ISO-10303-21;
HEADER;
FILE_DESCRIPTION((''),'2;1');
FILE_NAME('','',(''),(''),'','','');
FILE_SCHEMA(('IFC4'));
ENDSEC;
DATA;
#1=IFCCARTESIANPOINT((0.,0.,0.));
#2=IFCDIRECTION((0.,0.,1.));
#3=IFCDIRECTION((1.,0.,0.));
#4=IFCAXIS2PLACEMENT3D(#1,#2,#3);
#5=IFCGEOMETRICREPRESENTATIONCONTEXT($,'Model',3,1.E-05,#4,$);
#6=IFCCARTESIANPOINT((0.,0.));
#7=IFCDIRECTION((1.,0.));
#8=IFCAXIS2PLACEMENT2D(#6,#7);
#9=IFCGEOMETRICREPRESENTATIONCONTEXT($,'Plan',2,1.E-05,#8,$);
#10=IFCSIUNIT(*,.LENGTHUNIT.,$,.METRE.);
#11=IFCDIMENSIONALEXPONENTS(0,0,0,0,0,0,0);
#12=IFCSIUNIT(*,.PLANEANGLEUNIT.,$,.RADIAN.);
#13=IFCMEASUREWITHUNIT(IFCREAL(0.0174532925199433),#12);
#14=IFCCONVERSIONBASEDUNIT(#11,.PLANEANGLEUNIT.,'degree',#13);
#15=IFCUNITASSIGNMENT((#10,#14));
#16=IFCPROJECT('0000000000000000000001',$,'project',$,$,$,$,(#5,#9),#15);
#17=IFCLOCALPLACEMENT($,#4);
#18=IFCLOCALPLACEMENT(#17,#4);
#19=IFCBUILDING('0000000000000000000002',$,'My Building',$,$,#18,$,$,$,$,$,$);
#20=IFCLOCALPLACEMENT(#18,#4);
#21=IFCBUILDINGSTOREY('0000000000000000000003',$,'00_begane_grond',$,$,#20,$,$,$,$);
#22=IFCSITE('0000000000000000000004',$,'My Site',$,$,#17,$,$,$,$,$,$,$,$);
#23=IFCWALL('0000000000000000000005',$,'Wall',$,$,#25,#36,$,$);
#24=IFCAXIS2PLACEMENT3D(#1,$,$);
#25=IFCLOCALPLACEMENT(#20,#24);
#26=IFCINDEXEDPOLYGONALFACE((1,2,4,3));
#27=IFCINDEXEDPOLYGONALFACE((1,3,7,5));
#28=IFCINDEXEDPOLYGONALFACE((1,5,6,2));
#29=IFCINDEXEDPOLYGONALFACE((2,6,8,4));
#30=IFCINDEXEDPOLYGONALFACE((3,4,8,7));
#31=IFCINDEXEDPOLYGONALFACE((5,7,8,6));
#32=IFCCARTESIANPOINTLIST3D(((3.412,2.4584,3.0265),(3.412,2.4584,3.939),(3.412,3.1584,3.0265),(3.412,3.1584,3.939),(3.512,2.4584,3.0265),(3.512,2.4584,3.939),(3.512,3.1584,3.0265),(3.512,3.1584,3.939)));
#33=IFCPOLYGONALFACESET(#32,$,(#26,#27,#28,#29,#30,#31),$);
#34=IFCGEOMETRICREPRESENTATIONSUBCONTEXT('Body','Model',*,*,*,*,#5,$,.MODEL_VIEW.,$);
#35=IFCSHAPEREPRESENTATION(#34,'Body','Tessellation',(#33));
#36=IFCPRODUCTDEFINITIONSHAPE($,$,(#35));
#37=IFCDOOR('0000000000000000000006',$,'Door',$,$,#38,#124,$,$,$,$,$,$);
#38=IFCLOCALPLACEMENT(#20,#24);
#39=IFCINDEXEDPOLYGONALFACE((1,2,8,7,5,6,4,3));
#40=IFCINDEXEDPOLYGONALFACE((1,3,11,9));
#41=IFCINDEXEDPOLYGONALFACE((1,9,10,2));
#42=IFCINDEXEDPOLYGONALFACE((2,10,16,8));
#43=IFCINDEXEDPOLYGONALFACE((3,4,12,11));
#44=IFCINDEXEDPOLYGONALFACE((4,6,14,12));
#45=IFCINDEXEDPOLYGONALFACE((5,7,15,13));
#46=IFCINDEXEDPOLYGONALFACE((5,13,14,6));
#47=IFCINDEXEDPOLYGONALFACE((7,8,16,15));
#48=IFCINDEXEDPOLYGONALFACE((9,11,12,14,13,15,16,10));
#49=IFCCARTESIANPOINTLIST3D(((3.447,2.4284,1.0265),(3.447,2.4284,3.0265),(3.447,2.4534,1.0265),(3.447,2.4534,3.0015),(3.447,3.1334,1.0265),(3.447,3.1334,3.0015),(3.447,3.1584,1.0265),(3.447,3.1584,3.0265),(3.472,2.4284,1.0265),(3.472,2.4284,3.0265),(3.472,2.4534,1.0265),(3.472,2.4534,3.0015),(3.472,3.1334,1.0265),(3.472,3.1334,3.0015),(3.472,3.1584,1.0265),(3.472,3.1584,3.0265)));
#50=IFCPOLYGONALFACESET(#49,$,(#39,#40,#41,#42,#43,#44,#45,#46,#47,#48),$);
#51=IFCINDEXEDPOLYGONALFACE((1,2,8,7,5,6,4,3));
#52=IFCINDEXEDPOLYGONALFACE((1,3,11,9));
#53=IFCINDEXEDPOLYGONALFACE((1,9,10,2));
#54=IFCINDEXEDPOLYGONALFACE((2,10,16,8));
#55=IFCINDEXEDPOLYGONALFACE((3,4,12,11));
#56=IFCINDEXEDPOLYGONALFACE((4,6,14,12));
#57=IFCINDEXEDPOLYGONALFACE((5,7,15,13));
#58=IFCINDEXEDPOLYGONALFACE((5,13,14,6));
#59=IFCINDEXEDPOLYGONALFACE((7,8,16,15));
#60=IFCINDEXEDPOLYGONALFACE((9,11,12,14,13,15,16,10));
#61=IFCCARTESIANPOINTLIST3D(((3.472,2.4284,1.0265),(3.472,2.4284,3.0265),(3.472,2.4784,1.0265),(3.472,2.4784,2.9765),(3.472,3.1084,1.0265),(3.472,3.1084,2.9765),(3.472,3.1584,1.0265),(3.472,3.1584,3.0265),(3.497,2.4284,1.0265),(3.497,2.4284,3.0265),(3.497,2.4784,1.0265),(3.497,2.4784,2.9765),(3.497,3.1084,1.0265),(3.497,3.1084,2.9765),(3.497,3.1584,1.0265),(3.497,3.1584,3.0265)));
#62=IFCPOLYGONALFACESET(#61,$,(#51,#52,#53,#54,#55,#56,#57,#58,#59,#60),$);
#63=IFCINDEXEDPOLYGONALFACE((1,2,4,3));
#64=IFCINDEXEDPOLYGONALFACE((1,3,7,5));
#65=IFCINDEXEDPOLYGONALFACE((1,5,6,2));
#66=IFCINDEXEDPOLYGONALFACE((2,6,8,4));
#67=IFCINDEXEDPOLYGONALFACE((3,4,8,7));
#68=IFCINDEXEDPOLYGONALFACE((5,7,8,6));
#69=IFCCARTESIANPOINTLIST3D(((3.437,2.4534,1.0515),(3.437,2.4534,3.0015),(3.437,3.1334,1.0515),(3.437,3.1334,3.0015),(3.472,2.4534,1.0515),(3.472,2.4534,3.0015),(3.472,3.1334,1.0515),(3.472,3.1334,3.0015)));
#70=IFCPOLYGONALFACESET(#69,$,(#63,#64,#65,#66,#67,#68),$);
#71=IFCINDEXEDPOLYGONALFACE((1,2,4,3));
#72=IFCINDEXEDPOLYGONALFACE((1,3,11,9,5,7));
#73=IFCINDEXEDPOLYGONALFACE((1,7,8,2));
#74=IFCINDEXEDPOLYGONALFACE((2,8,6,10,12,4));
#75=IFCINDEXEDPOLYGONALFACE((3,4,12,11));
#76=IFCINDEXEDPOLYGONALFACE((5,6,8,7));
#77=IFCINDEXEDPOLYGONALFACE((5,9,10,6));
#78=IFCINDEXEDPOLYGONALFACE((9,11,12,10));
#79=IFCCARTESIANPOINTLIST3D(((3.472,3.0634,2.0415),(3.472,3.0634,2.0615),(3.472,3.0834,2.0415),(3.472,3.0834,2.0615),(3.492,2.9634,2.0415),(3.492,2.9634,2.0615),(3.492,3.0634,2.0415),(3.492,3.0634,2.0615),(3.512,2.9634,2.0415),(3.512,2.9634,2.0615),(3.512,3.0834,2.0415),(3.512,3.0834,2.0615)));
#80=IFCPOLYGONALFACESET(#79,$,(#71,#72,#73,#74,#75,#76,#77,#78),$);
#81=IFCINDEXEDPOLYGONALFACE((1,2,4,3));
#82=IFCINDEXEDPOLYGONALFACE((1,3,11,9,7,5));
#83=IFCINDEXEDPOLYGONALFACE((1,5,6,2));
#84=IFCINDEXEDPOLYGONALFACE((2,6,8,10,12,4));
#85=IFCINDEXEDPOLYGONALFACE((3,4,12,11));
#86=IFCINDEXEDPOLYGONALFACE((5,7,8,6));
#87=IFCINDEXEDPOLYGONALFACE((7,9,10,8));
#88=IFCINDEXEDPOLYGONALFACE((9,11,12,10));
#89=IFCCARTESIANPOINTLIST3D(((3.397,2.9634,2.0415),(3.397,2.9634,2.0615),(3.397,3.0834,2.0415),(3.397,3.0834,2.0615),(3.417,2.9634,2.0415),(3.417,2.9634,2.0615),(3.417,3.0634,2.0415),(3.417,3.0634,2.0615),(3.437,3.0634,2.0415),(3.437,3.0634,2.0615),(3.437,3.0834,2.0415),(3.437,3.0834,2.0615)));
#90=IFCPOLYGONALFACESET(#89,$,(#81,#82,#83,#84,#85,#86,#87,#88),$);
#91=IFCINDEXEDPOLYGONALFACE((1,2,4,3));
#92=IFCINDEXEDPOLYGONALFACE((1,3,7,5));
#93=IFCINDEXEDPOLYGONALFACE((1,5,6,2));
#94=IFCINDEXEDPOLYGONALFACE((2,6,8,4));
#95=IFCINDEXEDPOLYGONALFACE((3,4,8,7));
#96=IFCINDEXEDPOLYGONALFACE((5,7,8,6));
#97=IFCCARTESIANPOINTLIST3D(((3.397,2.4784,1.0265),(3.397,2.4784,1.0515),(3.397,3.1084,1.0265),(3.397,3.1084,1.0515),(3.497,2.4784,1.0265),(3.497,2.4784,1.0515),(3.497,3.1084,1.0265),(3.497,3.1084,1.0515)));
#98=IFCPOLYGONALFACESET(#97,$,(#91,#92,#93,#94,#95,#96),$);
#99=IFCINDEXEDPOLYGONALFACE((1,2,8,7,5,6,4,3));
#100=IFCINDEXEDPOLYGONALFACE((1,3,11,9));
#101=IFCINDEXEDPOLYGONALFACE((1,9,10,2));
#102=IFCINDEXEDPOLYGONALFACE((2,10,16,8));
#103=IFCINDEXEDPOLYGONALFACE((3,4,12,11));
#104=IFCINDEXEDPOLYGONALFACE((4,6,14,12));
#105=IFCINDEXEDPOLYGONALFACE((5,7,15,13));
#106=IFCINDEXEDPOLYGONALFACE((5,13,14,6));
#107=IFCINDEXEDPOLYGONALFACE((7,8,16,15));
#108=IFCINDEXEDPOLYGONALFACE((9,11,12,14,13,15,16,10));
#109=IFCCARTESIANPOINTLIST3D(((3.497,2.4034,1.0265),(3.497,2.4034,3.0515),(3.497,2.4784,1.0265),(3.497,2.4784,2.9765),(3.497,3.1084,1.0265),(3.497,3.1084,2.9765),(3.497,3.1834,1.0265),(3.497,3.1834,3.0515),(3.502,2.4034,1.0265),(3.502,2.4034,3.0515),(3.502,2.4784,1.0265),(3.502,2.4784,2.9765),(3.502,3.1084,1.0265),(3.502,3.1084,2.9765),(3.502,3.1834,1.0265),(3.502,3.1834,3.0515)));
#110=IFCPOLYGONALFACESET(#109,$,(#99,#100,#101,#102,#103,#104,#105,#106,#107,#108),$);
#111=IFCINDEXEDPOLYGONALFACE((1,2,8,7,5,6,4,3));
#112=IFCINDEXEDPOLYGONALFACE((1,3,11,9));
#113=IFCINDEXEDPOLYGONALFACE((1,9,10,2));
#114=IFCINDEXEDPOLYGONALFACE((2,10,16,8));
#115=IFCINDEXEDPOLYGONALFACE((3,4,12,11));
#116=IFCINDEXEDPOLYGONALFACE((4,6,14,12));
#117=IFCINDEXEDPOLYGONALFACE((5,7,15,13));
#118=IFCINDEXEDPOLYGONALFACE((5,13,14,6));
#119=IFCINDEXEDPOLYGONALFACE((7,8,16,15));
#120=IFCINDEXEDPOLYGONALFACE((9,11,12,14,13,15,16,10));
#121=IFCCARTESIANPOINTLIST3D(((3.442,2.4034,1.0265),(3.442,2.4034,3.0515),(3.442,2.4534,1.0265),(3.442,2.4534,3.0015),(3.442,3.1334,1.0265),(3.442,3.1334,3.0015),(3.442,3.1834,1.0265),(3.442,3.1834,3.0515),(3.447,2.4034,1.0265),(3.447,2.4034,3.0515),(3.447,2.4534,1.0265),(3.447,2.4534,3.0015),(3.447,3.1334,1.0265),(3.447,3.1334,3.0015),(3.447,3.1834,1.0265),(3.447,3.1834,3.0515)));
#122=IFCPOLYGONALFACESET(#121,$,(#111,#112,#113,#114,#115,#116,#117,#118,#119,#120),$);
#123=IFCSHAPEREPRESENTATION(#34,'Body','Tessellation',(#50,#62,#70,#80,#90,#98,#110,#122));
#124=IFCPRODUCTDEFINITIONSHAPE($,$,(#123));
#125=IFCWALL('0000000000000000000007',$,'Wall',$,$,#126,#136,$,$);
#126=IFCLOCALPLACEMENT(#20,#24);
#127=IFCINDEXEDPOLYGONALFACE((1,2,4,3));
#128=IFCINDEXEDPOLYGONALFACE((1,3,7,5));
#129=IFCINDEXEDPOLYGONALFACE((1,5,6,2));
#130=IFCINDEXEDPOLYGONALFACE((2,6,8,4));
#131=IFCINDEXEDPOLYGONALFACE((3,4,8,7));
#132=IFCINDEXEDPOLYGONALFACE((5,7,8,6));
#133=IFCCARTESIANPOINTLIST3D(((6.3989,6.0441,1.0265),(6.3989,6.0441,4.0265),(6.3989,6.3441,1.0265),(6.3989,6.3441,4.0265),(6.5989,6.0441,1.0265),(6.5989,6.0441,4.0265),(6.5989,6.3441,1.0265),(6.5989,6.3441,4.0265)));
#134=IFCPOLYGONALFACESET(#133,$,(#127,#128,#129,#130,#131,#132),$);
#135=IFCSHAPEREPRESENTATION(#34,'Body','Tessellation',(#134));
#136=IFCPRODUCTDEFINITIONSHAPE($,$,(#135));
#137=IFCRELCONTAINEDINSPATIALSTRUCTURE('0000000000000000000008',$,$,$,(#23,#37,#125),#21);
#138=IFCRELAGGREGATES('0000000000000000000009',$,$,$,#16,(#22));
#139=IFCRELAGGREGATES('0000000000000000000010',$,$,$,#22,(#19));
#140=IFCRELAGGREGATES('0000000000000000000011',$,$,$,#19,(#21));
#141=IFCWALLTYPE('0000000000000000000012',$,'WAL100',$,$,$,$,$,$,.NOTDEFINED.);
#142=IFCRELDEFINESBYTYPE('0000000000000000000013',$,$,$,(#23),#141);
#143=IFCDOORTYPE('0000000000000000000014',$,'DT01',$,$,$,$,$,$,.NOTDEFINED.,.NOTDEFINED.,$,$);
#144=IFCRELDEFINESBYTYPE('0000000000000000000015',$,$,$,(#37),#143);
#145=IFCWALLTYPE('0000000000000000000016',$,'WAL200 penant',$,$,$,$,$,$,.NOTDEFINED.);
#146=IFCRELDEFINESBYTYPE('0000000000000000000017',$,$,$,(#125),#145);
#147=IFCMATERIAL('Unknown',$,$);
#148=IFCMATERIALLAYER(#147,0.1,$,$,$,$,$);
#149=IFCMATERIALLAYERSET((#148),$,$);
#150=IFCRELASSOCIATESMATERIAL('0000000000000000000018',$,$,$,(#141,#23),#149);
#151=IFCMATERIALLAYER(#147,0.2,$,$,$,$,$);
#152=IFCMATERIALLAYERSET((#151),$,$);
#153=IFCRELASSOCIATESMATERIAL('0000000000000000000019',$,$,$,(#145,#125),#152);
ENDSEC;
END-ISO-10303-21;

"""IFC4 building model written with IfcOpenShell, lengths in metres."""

from ifc_helpers import new_model, entity, si_unit, converted_unit, frame, origin_with_axes, origin_2d_with_axis, place, context, subcontext, project, spatial, line, indexed_curve, outline, extrude, clip, halfspace, shape, source, transform, mapped, material, layer, layer_set, layer_usage, type_object, type_shapes, element, fill, save


model = new_model("IFC4")

# Units and contexts
model_context = context("Model", 3, precision=1e-05, world=origin_with_axes())
plan_context = context("Plan", 2, precision=1e-05, world=origin_2d_with_axis())
body_context_1 = subcontext(model_context, "Body", "Model", "MODEL_VIEW")
body_context_2 = subcontext(plan_context, "Body", "Plan", "PLAN_VIEW")
ifc_project = project(units=[si_unit("LENGTHUNIT", "METRE"), converted_unit("PLANEANGLEUNIT", "degree", entity("IfcReal", 0.0174532925199433), si_unit("PLANEANGLEUNIT", "RADIAN"), dimensions=[0, 0, 0, 0, 0, 0, 0])], contexts=[model_context, plan_context])

# Site, building, storey
site_placement = place(None, origin_with_axes())
site = spatial("IfcSite", under=ifc_project, at=site_placement, Name="My Site")
building_placement = place(site_placement, origin_with_axes())
building = spatial("IfcBuilding", under=site, at=building_placement, Name="My Building")
storey_placement = place(building_placement, origin_with_axes())
storey = spatial("IfcBuildingStorey", under=building, at=storey_placement, Name="00_begane_grond")

# Shared definitions
ifc_material = material(Name="Unknown")

# Shared definitions
ifc_layer_1 = layer(ifc_material, 0.1)
ifc_layer_set_1 = layer_set([ifc_layer_1])
wall_type_1 = type_object("IfcWallType", Name="WAL100", PredefinedType="NOTDEFINED", material=ifc_layer_set_1)

# Shared definitions
shared_shape_1 = source(origin_with_axes(), body_context_1, "Body", "SweptSolid", [
    extrude(outline(indexed_curve([(0.0, 0.0), (0.73, 0.0), (0.73, 2.0), (0.0, 2.0)], segments=[line(1, 2, 3, 4, 1)])), frame((0.0, -0.1, 0.0), z_axis=(0.0, -1.0, 0.0), x_axis=(1.0, 0.0, 0.0)), (0.0, 0.0, -1.0), 0.3),
])
door_type_1 = type_object("IfcDoorType", Name="DT01", OperationType="NOTDEFINED", PredefinedType="NOTDEFINED")
shared_shape_2 = source(origin_with_axes(), body_context_1, "Body", "SweptSolid", [
    extrude(outline(indexed_curve([(0.0, 0.0), (0.0, 2.0), (0.73, 2.0), (0.73, 0.0), (0.705, 0.0), (0.705, 1.975), (0.025, 1.975), (0.025, 0.0)], segments=[line(1, 2, 3, 4, 5, 6, 7, 8, 1)])), frame((0.0, 0.025, 0.0), z_axis=(0.0, -1.0, 0.0), x_axis=(1.0, 0.0, 0.0)), (0.0, 0.0, -1.0), 0.025),
    extrude(outline(indexed_curve([(0.0, 0.0), (0.0, 2.0), (0.73, 2.0), (0.73, 0.0), (0.68, 0.0), (0.68, 1.95), (0.05, 1.95), (0.05, 0.0)], segments=[line(1, 2, 3, 4, 5, 6, 7, 8, 1)])), frame((0.0, 0.0, 0.0), z_axis=(0.0, -1.0, 0.0), x_axis=(1.0, 0.0, 0.0)), (0.0, 0.0, -1.0), 0.025),
    extrude(outline(indexed_curve([(0.0, 0.0), (0.68, 0.0), (0.68, 0.035), (0.0, 0.035)], segments=[line(1, 2, 3, 4, 1)])), frame((0.025, 0.025, 0.025), z_axis=(0.0, 0.0, 1.0), x_axis=(1.0, 0.0, 0.0)), (0.0, 0.0, 1.0), 1.95),
    extrude(outline(indexed_curve([(0.0, 0.0), (0.0, -0.04), (-0.12, -0.04), (-0.12, -0.02), (-0.02, -0.02), (-0.02, 0.0)], segments=[line(1, 2, 3, 4, 5, 6, 1)])), frame((0.655, 0.025, 1.015), z_axis=(0.0, 0.0, 1.0), x_axis=(1.0, 0.0, 0.0)), (0.0, 0.0, 1.0), 0.02),
    extrude(outline(indexed_curve([(0.0, 0.0), (0.0, 0.04), (-0.12, 0.04), (-0.12, 0.02), (-0.02, 0.02), (-0.02, 0.0)], segments=[line(1, 2, 3, 4, 5, 6, 1)])), frame((0.655, 0.06, 1.015), z_axis=(0.0, 0.0, 1.0), x_axis=(1.0, 0.0, 0.0)), (0.0, 0.0, 1.0), 0.02),
    extrude(outline(indexed_curve([(0.0, 0.0), (0.63, 0.0), (0.63, 0.1), (0.0, 0.1)], segments=[line(1, 2, 3, 4, 1)])), frame((0.05, 0.0, 0.0), z_axis=(0.0, 0.0, 1.0), x_axis=(1.0, 0.0, 0.0)), (0.0, 0.0, 1.0), 0.025),
    extrude(outline(indexed_curve([(0.0, 0.0), (0.0, 2.025), (0.78, 2.025), (0.78, 0.0), (0.705, 0.0), (0.705, 1.95), (0.075, 1.95), (0.075, 0.0)], segments=[line(1, 2, 3, 4, 5, 6, 7, 8, 1)])), frame((-0.025, -0.005, 0.0), z_axis=(0.0, -1.0, 0.0), x_axis=(1.0, 0.0, 0.0)), (0.0, 0.0, -1.0), 0.005),
    extrude(outline(indexed_curve([(0.0, 0.0), (0.0, 2.025), (0.78, 2.025), (0.78, 0.0), (0.73, 0.0), (0.73, 1.975), (0.05, 1.975), (0.05, 0.0)], segments=[line(1, 2, 3, 4, 5, 6, 7, 8, 1)])), frame((-0.025, 0.05, 0.0), z_axis=(0.0, -1.0, 0.0), x_axis=(1.0, 0.0, 0.0)), (0.0, 0.0, -1.0), 0.005),
])
shared_shape_3 = source(origin_with_axes(), body_context_2, "Body", "Curve2D", [
    entity("IfcIndexedPolyCurve", entity("IfcCartesianPointList2D", [[0.0, 0.0], [0.0, 0.05], [0.025, 0.05], [0.025, 0.025], [0.05, 0.025], [0.05, 0.0]]), [entity("IfcLineIndex", [1, 2, 3, 4, 5, 6, 1])]),
    entity("IfcIndexedPolyCurve", entity("IfcCartesianPointList2D", [[0.73, 0.0], [0.73, 0.05], [0.705, 0.05], [0.705, 0.025], [0.68, 0.025], [0.68, 0.0]]), [entity("IfcLineIndex", [1, 2, 3, 4, 5, 6, 1])]),
    entity("IfcTrimmedCurve", entity("IfcEllipse", entity("IfcAxis2Placement2D", entity("IfcCartesianPoint", [0.06, 0.05]), entity("IfcDirection", [1.0, 0.0])), 0.645, 0.68), [entity("IfcCartesianPoint", [0.705, 0.05])], [entity("IfcCartesianPoint", [0.06, 0.73])], True, "CARTESIAN"),
    entity("IfcIndexedPolyCurve", entity("IfcCartesianPointList2D", [[0.025, 0.05], [0.06, 0.05], [0.06, 0.73], [0.025, 0.73]]), [entity("IfcLineIndex", [1, 2, 3, 4, 1])]),
])
type_shapes(door_type_1, [shared_shape_2, shared_shape_3])

# Wall, opening, door
ifc_layer_usage_1 = layer_usage(ifc_layer_set_1, "AXIS2", "POSITIVE", 0.0)
wall_1_placement = place(storey_placement, frame((3.412, 3.1584, 1.0265), z_axis=(0.0, 0.0, 1.0), x_axis=(-0.000001, -1.0, 0.0)))
wall_1 = element("IfcWall", 1, at=wall_1_placement, inside=storey, type_object=wall_type_1, material=ifc_layer_usage_1, Name="Wall", context=body_context_1, shape_type="Clipping", body=[
    clip(extrude(outline(indexed_curve([(0.0, 0.0), (0.0, 0.1), (0.7, 0.1), (0.7, 0.0), (0.0, 0.0)], self_intersect=False)), origin_with_axes(), (0.0, 0.0, 1.0), 3.939), halfspace(frame((0.0, 0.0, 2.9125), z_axis=(0.0, 0.0, 1.0), x_axis=(-1.0, 0.0, 0.0)), False)),
])
opening_1_placement = place(wall_1_placement, origin_with_axes())
opening_1 = element("IfcOpeningElement", 2, at=opening_1_placement, cuts=wall_1, PredefinedType="OPENING", context=body_context_1, shape_type="MappedRepresentation", body=[
    mapped(shared_shape_1, transform((0.0, 0.0, 0.0), x_axis=(1.0, 0.0, 0.0), y_axis=(0.0, 1.0, 0.0), z_axis=(0.0, 0.0, 1.0), scale=1.0)),
])
door_1_placement = place(opening_1_placement, frame((0.73, 0.085, 0.0), z_axis=(0.0, 0.0, 1.0), x_axis=(-1.0, 0.0, 0.0)))
door_1 = element("IfcDoor", 3, at=door_1_placement, inside=storey, type_object=door_type_1, Name="Door", shapes=[
    shape(body_context_1, "Body", "MappedRepresentation", [mapped(shared_shape_2, transform((0.0, 0.0, 0.0), x_axis=(1.0, 0.0, 0.0), y_axis=(0.0, 1.0, 0.0), z_axis=(0.0, 0.0, 1.0), scale=1.0))]),
    shape(body_context_2, "Body", "MappedRepresentation", [mapped(shared_shape_3, transform((0.0, 0.0, 0.0), x_axis=(1.0, 0.0, 0.0), y_axis=(0.0, 1.0, 0.0), z_axis=(0.0, 0.0, 1.0), scale=1.0))]),
])
fill(opening_1, door_1)

# Wall
ifc_layer_2 = layer(ifc_material, 0.2)
ifc_layer_set_2 = layer_set([ifc_layer_2])
ifc_layer_usage_2 = layer_usage(ifc_layer_set_2, "AXIS2", "POSITIVE", 0.0)
wall_type_2 = type_object("IfcWallType", Name="WAL200 penant", PredefinedType="NOTDEFINED", material=ifc_layer_set_2)
wall_2_placement = place(storey_placement, frame((6.5989, 6.0441, 1.0265), z_axis=(0.0, 0.0, 1.0), x_axis=(0.0, 1.0, 0.0)))
element("IfcWall", 4, at=wall_2_placement, inside=storey, type_object=wall_type_2, material=ifc_layer_usage_2, Name="Wall", context=body_context_1, shape_type="SweptSolid", body=[
    extrude(outline(indexed_curve([(0.0, 0.0), (0.0, 0.2), (0.3, 0.2), (0.3, 0.0), (0.0, 0.0)], self_intersect=False)), origin_with_axes(), (0.0, 0.0, 1.0), 3.0),
])

save(model, "model.ifc")
